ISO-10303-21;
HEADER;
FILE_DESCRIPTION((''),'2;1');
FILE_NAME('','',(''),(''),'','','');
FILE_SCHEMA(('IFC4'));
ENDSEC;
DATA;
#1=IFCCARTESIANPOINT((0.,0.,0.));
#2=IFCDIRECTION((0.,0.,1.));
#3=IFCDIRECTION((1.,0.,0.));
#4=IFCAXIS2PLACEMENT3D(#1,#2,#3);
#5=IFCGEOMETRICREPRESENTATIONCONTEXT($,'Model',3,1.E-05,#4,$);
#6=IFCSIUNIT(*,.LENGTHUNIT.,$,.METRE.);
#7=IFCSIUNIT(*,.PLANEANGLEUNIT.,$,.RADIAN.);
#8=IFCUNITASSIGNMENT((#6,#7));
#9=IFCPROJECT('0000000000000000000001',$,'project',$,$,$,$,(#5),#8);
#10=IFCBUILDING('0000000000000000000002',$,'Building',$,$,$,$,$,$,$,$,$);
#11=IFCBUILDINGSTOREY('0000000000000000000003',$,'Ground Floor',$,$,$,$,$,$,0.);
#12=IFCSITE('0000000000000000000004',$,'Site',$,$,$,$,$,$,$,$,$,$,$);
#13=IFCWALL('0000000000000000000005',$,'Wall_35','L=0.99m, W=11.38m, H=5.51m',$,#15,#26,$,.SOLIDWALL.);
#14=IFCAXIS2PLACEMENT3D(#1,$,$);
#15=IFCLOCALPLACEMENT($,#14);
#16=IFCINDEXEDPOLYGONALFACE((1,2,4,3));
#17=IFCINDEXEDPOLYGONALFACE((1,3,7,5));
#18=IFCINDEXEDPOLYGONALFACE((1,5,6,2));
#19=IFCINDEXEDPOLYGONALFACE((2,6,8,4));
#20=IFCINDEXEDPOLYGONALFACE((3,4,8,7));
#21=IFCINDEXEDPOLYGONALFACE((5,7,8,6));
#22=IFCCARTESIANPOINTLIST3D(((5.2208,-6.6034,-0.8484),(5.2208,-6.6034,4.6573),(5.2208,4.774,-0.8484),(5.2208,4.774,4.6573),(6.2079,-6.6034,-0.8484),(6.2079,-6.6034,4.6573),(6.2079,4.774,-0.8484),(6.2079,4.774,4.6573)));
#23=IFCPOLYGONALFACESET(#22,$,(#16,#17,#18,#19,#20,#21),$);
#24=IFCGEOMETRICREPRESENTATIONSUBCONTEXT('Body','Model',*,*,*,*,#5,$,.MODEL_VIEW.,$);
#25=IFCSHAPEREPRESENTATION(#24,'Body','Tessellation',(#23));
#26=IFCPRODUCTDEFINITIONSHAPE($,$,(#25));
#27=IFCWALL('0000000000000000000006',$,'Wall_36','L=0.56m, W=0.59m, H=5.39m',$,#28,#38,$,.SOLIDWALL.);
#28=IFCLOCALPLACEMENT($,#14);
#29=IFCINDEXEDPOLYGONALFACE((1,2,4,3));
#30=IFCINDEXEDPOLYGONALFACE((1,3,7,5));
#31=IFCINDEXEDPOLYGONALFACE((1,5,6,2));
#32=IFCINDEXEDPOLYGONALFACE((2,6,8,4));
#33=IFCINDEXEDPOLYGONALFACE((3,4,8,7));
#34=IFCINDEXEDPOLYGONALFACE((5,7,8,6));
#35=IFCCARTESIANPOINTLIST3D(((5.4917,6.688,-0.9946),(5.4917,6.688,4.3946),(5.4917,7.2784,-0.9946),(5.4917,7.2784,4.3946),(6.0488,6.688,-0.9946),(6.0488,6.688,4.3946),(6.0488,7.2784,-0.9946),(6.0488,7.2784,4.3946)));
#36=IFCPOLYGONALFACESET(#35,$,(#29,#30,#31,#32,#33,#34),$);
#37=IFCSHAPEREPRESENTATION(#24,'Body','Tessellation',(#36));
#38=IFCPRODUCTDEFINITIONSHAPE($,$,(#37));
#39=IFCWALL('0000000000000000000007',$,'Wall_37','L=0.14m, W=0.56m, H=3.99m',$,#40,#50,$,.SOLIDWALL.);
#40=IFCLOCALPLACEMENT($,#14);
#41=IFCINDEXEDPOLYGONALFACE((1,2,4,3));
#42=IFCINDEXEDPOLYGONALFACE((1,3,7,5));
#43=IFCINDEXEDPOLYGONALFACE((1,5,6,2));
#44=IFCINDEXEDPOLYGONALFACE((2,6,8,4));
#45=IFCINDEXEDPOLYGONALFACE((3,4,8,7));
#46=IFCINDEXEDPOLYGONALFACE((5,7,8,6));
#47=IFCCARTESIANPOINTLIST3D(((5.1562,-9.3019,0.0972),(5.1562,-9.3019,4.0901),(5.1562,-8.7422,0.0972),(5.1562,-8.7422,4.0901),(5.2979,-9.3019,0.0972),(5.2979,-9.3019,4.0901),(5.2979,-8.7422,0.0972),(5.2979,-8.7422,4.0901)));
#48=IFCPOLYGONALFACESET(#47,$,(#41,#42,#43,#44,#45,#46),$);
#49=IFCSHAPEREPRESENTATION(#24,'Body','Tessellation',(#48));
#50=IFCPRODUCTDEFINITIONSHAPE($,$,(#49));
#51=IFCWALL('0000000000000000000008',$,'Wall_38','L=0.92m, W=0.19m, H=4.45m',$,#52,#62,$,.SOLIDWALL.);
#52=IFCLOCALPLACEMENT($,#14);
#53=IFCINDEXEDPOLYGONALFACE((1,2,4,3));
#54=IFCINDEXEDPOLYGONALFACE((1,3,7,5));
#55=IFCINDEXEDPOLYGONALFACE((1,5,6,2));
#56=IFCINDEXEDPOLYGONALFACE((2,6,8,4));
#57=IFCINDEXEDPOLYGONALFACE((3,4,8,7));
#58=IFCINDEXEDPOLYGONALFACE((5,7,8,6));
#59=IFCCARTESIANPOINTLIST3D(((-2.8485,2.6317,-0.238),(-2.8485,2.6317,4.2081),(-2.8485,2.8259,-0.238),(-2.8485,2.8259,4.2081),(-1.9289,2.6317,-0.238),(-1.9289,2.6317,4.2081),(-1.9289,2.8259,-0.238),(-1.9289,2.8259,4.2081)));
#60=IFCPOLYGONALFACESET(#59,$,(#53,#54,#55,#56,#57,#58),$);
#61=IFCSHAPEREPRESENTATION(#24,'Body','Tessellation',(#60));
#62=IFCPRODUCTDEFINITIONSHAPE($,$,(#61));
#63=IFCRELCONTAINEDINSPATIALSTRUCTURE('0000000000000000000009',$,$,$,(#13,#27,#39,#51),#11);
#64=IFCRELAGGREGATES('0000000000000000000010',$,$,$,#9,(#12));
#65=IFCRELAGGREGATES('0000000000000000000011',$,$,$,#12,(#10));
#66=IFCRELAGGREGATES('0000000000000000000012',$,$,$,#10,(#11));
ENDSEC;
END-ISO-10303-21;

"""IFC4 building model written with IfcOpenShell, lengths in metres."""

from ifc_helpers import new_model, si_unit, frame, origin_with_axes, origin_2d, context, subcontext, project, spatial, rectangle, extrude, element, save


model = new_model("IFC4")

# Units and contexts
model_context = context("Model", 3, precision=1e-05, world=origin_with_axes())
body_context = subcontext(model_context, "Body", "Model", "MODEL_VIEW")
ifc_project = project(units=[si_unit("LENGTHUNIT", "METRE"), si_unit("PLANEANGLEUNIT", "RADIAN")], contexts=[model_context])

# Site, building, storey
site = spatial("IfcSite", under=ifc_project, Name="Site")
building = spatial("IfcBuilding", under=site, Name="Building")
storey = spatial("IfcBuildingStorey", under=building, Name="Ground Floor", Elevation=0.0)

# Walls
element("IfcWall", 1, inside=storey, Name="Wall_35", Description="L=0.99m, W=11.38m, H=5.51m", PredefinedType="SOLIDWALL", context=body_context, shape_type="SweptSolid", body=[
    extrude(rectangle(XDim=0.9872, YDim=11.3773, at=origin_2d()), frame((5.7144, -0.9147, -0.8484), z_axis=(0.0, 0.0, 1.0), x_axis=(1.0, 0.0, 0.0)), (0.0, 0.0, 1.0), 5.5057),
])
element("IfcWall", 2, inside=storey, Name="Wall_36", Description="L=0.56m, W=0.59m, H=5.39m", PredefinedType="SOLIDWALL", context=body_context, shape_type="SweptSolid", body=[
    extrude(rectangle(XDim=0.557, YDim=0.5904, at=origin_2d()), frame((5.7703, 6.9832, -0.9946), z_axis=(0.0, 0.0, 1.0), x_axis=(1.0, 0.0, 0.0)), (0.0, 0.0, 1.0), 5.3891),
])
element("IfcWall", 3, inside=storey, Name="Wall_37", Description="L=0.14m, W=0.56m, H=3.99m", PredefinedType="SOLIDWALL", context=body_context, shape_type="SweptSolid", body=[
    extrude(rectangle(XDim=0.1417, YDim=0.5597, at=origin_2d()), frame((5.227, -9.0221, 0.0972), z_axis=(0.0, 0.0, 1.0), x_axis=(1.0, 0.0, 0.0)), (0.0, 0.0, 1.0), 3.9929),
])
element("IfcWall", 4, inside=storey, Name="Wall_38", Description="L=0.92m, W=0.19m, H=4.45m", PredefinedType="SOLIDWALL", context=body_context, shape_type="SweptSolid", body=[
    extrude(rectangle(XDim=0.9196, YDim=0.1942, at=origin_2d()), frame((-2.3887, 2.7288, -0.238), z_axis=(0.0, 0.0, 1.0), x_axis=(1.0, 0.0, 0.0)), (0.0, 0.0, 1.0), 4.4461),
])

save(model, "model.ifc")
